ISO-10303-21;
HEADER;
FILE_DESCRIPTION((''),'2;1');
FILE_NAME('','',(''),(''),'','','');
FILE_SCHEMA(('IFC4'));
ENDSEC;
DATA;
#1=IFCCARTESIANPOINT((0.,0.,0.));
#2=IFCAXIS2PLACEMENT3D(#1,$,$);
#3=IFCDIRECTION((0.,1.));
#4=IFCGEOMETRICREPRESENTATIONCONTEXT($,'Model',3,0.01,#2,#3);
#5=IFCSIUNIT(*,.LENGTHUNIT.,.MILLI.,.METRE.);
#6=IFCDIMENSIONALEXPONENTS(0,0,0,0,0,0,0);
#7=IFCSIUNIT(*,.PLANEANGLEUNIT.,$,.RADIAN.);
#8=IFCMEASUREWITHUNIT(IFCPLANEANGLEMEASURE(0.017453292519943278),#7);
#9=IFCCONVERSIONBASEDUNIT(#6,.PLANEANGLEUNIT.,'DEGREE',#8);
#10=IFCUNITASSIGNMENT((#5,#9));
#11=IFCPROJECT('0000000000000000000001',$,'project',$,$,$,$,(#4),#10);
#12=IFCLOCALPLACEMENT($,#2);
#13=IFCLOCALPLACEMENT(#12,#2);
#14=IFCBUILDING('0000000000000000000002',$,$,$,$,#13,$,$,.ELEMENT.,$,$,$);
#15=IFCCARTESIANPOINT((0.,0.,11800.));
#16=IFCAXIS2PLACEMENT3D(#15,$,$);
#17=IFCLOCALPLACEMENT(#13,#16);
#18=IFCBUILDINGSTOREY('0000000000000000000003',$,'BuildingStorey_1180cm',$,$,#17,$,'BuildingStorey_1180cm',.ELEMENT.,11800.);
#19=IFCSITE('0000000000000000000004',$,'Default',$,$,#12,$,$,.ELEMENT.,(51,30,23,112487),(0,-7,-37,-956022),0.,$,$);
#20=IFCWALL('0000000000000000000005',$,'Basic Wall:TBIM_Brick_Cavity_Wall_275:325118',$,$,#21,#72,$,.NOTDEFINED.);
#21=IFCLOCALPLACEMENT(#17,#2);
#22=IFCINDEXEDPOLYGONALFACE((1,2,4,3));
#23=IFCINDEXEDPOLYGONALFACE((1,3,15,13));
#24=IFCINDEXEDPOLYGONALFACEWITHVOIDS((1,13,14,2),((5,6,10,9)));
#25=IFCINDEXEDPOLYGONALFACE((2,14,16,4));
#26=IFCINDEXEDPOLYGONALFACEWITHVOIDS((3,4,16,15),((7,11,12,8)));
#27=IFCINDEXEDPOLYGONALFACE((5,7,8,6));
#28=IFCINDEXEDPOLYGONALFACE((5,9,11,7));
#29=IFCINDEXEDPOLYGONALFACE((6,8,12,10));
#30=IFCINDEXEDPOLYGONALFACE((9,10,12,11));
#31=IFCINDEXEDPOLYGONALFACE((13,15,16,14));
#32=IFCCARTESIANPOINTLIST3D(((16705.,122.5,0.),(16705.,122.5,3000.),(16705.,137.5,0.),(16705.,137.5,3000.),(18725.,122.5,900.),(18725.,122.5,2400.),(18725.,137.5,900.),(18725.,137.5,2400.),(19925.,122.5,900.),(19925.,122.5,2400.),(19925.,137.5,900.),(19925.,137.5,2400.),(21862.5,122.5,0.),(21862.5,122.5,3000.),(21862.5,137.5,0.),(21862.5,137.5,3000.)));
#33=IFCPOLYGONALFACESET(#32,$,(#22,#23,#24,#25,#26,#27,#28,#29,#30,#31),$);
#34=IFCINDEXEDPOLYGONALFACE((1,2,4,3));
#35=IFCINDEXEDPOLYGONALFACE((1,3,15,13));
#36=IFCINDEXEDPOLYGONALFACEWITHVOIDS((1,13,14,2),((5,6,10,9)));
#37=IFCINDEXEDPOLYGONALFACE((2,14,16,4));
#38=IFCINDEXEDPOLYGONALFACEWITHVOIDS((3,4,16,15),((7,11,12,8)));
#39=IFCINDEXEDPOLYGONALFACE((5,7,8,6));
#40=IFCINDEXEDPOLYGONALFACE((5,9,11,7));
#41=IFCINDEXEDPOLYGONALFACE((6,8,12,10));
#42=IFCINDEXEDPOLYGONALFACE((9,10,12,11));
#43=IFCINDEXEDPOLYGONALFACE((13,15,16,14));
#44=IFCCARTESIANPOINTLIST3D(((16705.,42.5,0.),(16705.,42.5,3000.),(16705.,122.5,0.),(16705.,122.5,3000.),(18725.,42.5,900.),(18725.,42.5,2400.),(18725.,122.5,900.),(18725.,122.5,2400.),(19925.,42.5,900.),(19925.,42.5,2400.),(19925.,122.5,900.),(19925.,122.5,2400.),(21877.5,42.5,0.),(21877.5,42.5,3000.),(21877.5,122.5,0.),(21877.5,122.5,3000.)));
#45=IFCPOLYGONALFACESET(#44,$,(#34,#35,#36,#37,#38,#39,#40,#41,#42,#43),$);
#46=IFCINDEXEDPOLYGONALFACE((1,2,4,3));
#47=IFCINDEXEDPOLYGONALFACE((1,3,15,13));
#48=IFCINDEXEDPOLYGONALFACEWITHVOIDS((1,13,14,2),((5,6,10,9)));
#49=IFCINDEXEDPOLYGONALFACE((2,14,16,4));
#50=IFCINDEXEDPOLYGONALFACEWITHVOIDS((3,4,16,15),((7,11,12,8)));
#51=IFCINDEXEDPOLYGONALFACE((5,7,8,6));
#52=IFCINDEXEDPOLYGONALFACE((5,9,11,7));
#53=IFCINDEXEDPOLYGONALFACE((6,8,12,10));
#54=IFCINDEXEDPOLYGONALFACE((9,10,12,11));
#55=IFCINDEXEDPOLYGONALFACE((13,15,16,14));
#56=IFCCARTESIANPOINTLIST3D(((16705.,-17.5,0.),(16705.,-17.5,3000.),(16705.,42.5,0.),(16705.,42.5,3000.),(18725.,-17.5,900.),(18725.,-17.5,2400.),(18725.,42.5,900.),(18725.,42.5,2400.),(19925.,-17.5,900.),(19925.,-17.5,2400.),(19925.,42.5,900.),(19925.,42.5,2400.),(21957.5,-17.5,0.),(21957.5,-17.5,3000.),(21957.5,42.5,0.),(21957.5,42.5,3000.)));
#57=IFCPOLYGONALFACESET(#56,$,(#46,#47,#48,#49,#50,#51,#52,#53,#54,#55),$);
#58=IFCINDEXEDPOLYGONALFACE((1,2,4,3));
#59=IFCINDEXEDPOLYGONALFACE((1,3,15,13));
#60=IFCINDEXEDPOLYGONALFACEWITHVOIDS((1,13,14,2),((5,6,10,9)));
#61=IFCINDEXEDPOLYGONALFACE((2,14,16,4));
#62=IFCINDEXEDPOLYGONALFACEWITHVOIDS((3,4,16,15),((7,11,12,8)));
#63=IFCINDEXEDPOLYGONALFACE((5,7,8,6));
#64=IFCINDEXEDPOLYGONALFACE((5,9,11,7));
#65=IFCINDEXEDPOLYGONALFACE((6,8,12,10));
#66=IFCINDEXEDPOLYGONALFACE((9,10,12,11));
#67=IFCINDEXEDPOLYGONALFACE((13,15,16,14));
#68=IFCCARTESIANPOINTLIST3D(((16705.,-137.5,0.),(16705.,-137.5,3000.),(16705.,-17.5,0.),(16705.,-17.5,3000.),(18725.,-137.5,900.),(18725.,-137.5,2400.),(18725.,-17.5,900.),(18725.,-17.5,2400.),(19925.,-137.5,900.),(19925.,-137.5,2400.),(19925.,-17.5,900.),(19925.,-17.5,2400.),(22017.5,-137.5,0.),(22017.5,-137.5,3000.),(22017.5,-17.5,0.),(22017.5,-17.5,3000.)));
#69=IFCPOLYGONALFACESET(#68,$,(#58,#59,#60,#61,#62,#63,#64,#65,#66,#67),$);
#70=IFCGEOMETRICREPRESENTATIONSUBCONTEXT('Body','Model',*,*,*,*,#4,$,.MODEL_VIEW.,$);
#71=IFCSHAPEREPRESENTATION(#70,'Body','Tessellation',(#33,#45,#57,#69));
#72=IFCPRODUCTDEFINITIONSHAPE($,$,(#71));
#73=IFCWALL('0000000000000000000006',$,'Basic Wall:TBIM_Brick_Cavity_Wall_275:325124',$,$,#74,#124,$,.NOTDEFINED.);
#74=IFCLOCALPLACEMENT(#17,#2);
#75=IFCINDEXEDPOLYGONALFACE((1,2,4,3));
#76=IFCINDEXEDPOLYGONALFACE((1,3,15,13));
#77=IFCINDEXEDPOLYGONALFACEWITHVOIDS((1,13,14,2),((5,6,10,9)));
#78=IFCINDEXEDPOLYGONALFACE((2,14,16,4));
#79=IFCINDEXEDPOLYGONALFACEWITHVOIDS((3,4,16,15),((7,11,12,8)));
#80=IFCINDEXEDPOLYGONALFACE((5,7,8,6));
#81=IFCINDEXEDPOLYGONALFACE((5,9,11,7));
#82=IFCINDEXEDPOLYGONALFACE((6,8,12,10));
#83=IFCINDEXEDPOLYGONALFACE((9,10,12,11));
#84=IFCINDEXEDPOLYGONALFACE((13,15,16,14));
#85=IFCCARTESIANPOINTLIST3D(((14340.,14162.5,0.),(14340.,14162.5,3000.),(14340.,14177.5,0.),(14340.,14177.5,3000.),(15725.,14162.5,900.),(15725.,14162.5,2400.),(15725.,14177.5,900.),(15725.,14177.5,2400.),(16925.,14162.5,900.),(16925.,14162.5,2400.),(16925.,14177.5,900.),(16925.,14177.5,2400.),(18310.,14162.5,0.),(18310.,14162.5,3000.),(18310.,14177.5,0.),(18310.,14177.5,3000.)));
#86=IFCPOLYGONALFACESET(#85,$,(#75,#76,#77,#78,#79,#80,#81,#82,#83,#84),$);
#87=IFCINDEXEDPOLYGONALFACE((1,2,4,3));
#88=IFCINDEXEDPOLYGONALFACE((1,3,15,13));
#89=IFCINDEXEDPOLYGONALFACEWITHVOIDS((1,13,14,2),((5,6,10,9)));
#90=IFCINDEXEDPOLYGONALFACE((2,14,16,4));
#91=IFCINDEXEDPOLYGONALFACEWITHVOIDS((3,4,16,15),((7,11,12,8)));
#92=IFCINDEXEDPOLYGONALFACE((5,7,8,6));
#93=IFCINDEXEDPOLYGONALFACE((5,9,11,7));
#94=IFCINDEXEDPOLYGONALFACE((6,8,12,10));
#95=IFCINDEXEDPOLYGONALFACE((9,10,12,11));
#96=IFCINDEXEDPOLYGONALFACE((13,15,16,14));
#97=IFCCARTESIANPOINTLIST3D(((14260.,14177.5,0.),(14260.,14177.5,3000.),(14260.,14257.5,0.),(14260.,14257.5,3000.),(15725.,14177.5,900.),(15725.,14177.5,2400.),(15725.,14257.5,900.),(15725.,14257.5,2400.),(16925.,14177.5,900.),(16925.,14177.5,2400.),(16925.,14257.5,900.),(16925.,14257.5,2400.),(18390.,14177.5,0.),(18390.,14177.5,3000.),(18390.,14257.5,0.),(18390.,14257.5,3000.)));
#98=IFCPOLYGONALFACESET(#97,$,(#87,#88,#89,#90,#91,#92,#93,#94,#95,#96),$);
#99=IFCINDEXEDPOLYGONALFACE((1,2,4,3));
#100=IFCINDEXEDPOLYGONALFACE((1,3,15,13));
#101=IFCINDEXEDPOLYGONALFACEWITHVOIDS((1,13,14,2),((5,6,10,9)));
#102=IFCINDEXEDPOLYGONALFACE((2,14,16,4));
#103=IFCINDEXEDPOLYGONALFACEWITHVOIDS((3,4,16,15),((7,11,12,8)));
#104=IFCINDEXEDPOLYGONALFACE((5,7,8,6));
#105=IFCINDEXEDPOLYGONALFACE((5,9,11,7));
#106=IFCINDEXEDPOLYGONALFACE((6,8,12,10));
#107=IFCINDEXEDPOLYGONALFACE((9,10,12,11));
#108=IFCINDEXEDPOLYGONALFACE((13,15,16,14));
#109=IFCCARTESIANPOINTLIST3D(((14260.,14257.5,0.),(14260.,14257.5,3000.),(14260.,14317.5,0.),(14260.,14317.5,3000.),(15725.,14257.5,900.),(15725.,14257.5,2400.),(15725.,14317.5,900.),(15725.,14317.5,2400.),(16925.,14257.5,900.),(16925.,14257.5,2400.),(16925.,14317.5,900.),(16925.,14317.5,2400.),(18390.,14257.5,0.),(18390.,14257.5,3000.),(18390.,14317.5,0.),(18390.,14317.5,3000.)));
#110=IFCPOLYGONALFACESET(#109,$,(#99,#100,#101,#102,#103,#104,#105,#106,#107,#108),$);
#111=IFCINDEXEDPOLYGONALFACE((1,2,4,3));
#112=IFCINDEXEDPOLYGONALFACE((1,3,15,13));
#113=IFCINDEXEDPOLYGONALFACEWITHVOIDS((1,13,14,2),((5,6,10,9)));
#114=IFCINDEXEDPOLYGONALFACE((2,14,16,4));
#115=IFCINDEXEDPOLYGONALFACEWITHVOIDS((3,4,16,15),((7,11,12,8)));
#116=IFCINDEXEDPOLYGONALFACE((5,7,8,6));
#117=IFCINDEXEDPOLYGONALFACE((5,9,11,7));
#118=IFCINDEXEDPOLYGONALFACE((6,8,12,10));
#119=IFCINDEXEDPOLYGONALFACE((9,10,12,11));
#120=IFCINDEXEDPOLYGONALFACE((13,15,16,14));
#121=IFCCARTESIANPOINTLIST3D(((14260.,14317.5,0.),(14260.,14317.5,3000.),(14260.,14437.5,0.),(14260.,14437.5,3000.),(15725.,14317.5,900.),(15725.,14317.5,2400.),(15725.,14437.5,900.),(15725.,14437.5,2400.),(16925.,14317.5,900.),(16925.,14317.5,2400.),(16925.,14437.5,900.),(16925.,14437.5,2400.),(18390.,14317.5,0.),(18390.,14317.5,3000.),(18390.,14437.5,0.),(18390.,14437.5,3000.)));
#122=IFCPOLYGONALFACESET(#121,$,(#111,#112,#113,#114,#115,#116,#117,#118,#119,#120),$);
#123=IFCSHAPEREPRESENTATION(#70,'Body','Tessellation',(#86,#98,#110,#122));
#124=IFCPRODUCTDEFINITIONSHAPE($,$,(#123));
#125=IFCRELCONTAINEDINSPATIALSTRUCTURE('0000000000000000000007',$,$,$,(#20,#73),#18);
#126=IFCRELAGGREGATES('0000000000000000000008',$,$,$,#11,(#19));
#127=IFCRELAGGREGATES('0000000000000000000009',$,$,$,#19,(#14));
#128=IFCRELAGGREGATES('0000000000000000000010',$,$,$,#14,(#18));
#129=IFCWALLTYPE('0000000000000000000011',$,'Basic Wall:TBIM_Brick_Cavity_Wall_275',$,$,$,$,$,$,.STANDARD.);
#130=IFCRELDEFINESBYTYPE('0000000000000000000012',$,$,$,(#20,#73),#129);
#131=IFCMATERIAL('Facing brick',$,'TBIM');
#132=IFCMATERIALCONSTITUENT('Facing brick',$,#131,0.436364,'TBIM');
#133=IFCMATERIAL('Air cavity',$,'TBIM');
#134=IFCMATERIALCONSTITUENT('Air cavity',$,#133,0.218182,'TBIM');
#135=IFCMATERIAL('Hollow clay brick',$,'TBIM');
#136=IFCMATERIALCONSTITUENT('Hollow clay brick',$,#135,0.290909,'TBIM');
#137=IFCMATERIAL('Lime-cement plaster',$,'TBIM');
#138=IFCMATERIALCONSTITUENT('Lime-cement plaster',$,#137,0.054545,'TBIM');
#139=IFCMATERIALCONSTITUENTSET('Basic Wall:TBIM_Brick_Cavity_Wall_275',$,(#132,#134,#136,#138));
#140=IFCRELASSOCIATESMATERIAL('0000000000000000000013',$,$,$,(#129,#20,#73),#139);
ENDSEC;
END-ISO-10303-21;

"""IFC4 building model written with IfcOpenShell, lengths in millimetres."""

from ifc_helpers import new_model, entity, si_unit, converted_unit, direction, frame, origin, place, context, subcontext, project, spatial, indexed_curve, outline, extrude, material, constituent, constituent_set, type_object, element, save


model = new_model("IFC4")

# Units and contexts
model_context = context("Model", 3, precision=0.01, world=origin(), true_north=direction((0.0, 1.0)))
body_context = subcontext(model_context, "Body", "Model", "MODEL_VIEW")
ifc_project = project(units=[si_unit("LENGTHUNIT", "METRE", prefix="MILLI"), converted_unit("PLANEANGLEUNIT", "DEGREE", entity("IfcPlaneAngleMeasure", 0.017453292519943278), si_unit("PLANEANGLEUNIT", "RADIAN"), dimensions=[0, 0, 0, 0, 0, 0, 0])], contexts=[model_context])

# Site, building, storey
site_placement = place(None, origin())
site = spatial("IfcSite", under=ifc_project, at=site_placement, Name="Default", CompositionType="ELEMENT", RefLatitude=(51, 30, 23, 112487), RefLongitude=(0, -7, -37, -956022), RefElevation=0.0)
building_placement = place(site_placement, origin())
building = spatial("IfcBuilding", under=site, at=building_placement, CompositionType="ELEMENT")
storey_placement = place(building_placement, frame((0.0, 0.0, 11800.0)))
storey = spatial("IfcBuildingStorey", under=building, at=storey_placement, Name="BuildingStorey_1180cm", LongName="BuildingStorey_1180cm", CompositionType="ELEMENT", Elevation=11800.0)

# Walls, openings
ifc_material_1 = material(Name="Facing brick", Category="TBIM")
ifc_constituent_1 = constituent(ifc_material_1, Name="Facing brick", Category="TBIM", fraction=0.436364)
ifc_material_2 = material(Name="Air cavity", Category="TBIM")
ifc_constituent_2 = constituent(ifc_material_2, Name="Air cavity", Category="TBIM", fraction=0.218182)
ifc_material_3 = material(Name="Hollow clay brick", Category="TBIM")
ifc_constituent_3 = constituent(ifc_material_3, Name="Hollow clay brick", Category="TBIM", fraction=0.290909)
ifc_material_4 = material(Name="Lime-cement plaster", Category="TBIM")
ifc_constituent_4 = constituent(ifc_material_4, Name="Lime-cement plaster", Category="TBIM", fraction=0.054545)
ifc_constituent_set_1 = constituent_set(constituents=[ifc_constituent_1, ifc_constituent_2, ifc_constituent_3, ifc_constituent_4], Name="Basic Wall:TBIM_Brick_Cavity_Wall_275")
wall_type_1 = type_object("IfcWallType", Name="Basic Wall:TBIM_Brick_Cavity_Wall_275", PredefinedType="STANDARD", material=ifc_constituent_set_1)
wall_1_placement = place(storey_placement, frame((16705.0, 0.0, 0.0)))
wall_1 = element("IfcWall", 1, at=wall_1_placement, inside=storey, type_object=wall_type_1, material=ifc_constituent_set_1, Name="Basic Wall:TBIM_Brick_Cavity_Wall_275:325118", PredefinedType="NOTDEFINED", context=body_context, shape_type="SweptSolid", body=[
    extrude(outline(indexed_curve([(-1500.0, -2578.8), (1500.0, -2578.8), (1500.0, 2578.8), (-1500.0, 2578.8), (-1500.0, -2578.8)], self_intersect=False), holes=[indexed_curve([(-600.0, -558.8), (-600.0, 641.2), (900.0, 641.2), (900.0, -558.8), (-600.0, -558.8)], self_intersect=False)]), frame((2578.8, 122.5, 1500.0), z_axis=(0.0, 1.0, 0.0), x_axis=(0.0, 0.0, 1.0)), (0.0, 0.0, 1.0), 15.0),
    extrude(outline(indexed_curve([(-1500.0, -2586.3), (1500.0, -2586.3), (1500.0, 2586.3), (-1500.0, 2586.3), (-1500.0, -2586.3)], self_intersect=False), holes=[indexed_curve([(-600.0, -566.3), (-600.0, 633.7), (900.0, 633.7), (900.0, -566.3), (-600.0, -566.3)], self_intersect=False)]), frame((2586.3, 42.5, 1500.0), z_axis=(0.0, 1.0, 0.0), x_axis=(0.0, 0.0, 1.0)), (0.0, 0.0, 1.0), 80.0),
    extrude(outline(indexed_curve([(-1500.0, -2626.3), (1500.0, -2626.3), (1500.0, 2626.3), (-1500.0, 2626.3), (-1500.0, -2626.3)], self_intersect=False), holes=[indexed_curve([(-600.0, -606.3), (-600.0, 593.7), (900.0, 593.7), (900.0, -606.3), (-600.0, -606.3)], self_intersect=False)]), frame((2626.3, -17.5, 1500.0), z_axis=(0.0, 1.0, 0.0), x_axis=(0.0, 0.0, 1.0)), (0.0, 0.0, 1.0), 60.0),
    extrude(outline(indexed_curve([(-1500.0, -2656.3), (1500.0, -2656.3), (1500.0, 2656.3), (-1500.0, 2656.3), (-1500.0, -2656.3)], self_intersect=False), holes=[indexed_curve([(900.0, -636.3), (-600.0, -636.3), (-600.0, 563.7), (900.0, 563.7), (900.0, -636.3)], self_intersect=False)]), frame((2656.3, -137.5, 1500.0), z_axis=(0.0, 1.0, 0.0), x_axis=(0.0, 0.0, 1.0)), (0.0, 0.0, 1.0), 120.0),
])
opening_1_placement = place(wall_1_placement, frame((2020.0, -137.5, 900.0)))
element("IfcOpeningElement", 2, at=opening_1_placement, cuts=wall_1, PredefinedType="OPENING", context=body_context, shape_type="SweptSolid", body=[
    extrude(outline(indexed_curve([(1500.0, 0.0), (1500.0, 1200.0), (0.0, 1200.0), (0.0, 0.0), (1500.0, 0.0)], self_intersect=False)), frame((0.0, 0.0, 0.0), z_axis=(0.0, 1.0, 0.0), x_axis=(0.0, 0.0, 1.0)), (0.0, 0.0, 1.0), 275.0),
])
wall_2_placement = place(storey_placement, frame((14245.0, 14300.0, 0.0)))
wall_2 = element("IfcWall", 3, at=wall_2_placement, inside=storey, type_object=wall_type_1, material=ifc_constituent_set_1, Name="Basic Wall:TBIM_Brick_Cavity_Wall_275:325124", PredefinedType="NOTDEFINED", context=body_context, shape_type="SweptSolid", body=[
    extrude(outline(indexed_curve([(-1500.0, -1985.0), (1500.0, -1985.0), (1500.0, -1970.0), (1500.0, 1970.0), (1500.0, 1985.0), (-1500.0, 1985.0), (-1500.0, 1970.0), (-1500.0, -1970.0), (-1500.0, -1985.0)], self_intersect=False), holes=[indexed_curve([(900.0, -600.0), (-600.0, -600.0), (-600.0, 600.0), (900.0, 600.0), (900.0, -600.0)], self_intersect=False)]), frame((2080.0, -137.5, 1500.0), z_axis=(0.0, 1.0, 0.0), x_axis=(0.0, 0.0, 1.0)), (0.0, 0.0, 1.0), 15.0),
    extrude(outline(indexed_curve([(-1500.0, -2065.0), (1500.0, -2065.0), (1500.0, 2065.0), (-1500.0, 2065.0), (-1500.0, -2065.0)], self_intersect=False), holes=[indexed_curve([(-600.0, -600.0), (-600.0, 600.0), (900.0, 600.0), (900.0, -600.0), (-600.0, -600.0)], self_intersect=False)]), frame((2080.0, -122.5, 1500.0), z_axis=(0.0, 1.0, 0.0), x_axis=(0.0, 0.0, 1.0)), (0.0, 0.0, 1.0), 80.0),
    extrude(outline(indexed_curve([(-1500.0, -2065.0), (1500.0, -2065.0), (1500.0, 2065.0), (-1500.0, 2065.0), (-1500.0, -2065.0)], self_intersect=False), holes=[indexed_curve([(-600.0, -600.0), (-600.0, 600.0), (900.0, 600.0), (900.0, -600.0), (-600.0, -600.0)], self_intersect=False)]), frame((2080.0, -42.5, 1500.0), z_axis=(0.0, 1.0, 0.0), x_axis=(0.0, 0.0, 1.0)), (0.0, 0.0, 1.0), 60.0),
    extrude(outline(indexed_curve([(-1500.0, -2065.0), (1500.0, -2065.0), (1500.0, 2065.0), (-1500.0, 2065.0), (-1500.0, -2065.0)], self_intersect=False), holes=[indexed_curve([(-600.0, -600.0), (-600.0, 600.0), (900.0, 600.0), (900.0, -600.0), (-600.0, -600.0)], self_intersect=False)]), frame((2080.0, 17.5, 1500.0), z_axis=(0.0, 1.0, 0.0), x_axis=(0.0, 0.0, 1.0)), (0.0, 0.0, 1.0), 120.0),
])
opening_2_placement = place(wall_2_placement, frame((1480.0, -137.5, 900.0)))
element("IfcOpeningElement", 4, at=opening_2_placement, cuts=wall_2, PredefinedType="OPENING", context=body_context, shape_type="SweptSolid", body=[
    extrude(outline(indexed_curve([(1500.0, 0.0), (1500.0, 1200.0), (0.0, 1200.0), (0.0, 0.0), (1500.0, 0.0)], self_intersect=False)), frame((0.0, 0.0, 0.0), z_axis=(0.0, 1.0, 0.0), x_axis=(0.0, 0.0, 1.0)), (0.0, 0.0, 1.0), 275.0),
])

save(model, "model.ifc")
